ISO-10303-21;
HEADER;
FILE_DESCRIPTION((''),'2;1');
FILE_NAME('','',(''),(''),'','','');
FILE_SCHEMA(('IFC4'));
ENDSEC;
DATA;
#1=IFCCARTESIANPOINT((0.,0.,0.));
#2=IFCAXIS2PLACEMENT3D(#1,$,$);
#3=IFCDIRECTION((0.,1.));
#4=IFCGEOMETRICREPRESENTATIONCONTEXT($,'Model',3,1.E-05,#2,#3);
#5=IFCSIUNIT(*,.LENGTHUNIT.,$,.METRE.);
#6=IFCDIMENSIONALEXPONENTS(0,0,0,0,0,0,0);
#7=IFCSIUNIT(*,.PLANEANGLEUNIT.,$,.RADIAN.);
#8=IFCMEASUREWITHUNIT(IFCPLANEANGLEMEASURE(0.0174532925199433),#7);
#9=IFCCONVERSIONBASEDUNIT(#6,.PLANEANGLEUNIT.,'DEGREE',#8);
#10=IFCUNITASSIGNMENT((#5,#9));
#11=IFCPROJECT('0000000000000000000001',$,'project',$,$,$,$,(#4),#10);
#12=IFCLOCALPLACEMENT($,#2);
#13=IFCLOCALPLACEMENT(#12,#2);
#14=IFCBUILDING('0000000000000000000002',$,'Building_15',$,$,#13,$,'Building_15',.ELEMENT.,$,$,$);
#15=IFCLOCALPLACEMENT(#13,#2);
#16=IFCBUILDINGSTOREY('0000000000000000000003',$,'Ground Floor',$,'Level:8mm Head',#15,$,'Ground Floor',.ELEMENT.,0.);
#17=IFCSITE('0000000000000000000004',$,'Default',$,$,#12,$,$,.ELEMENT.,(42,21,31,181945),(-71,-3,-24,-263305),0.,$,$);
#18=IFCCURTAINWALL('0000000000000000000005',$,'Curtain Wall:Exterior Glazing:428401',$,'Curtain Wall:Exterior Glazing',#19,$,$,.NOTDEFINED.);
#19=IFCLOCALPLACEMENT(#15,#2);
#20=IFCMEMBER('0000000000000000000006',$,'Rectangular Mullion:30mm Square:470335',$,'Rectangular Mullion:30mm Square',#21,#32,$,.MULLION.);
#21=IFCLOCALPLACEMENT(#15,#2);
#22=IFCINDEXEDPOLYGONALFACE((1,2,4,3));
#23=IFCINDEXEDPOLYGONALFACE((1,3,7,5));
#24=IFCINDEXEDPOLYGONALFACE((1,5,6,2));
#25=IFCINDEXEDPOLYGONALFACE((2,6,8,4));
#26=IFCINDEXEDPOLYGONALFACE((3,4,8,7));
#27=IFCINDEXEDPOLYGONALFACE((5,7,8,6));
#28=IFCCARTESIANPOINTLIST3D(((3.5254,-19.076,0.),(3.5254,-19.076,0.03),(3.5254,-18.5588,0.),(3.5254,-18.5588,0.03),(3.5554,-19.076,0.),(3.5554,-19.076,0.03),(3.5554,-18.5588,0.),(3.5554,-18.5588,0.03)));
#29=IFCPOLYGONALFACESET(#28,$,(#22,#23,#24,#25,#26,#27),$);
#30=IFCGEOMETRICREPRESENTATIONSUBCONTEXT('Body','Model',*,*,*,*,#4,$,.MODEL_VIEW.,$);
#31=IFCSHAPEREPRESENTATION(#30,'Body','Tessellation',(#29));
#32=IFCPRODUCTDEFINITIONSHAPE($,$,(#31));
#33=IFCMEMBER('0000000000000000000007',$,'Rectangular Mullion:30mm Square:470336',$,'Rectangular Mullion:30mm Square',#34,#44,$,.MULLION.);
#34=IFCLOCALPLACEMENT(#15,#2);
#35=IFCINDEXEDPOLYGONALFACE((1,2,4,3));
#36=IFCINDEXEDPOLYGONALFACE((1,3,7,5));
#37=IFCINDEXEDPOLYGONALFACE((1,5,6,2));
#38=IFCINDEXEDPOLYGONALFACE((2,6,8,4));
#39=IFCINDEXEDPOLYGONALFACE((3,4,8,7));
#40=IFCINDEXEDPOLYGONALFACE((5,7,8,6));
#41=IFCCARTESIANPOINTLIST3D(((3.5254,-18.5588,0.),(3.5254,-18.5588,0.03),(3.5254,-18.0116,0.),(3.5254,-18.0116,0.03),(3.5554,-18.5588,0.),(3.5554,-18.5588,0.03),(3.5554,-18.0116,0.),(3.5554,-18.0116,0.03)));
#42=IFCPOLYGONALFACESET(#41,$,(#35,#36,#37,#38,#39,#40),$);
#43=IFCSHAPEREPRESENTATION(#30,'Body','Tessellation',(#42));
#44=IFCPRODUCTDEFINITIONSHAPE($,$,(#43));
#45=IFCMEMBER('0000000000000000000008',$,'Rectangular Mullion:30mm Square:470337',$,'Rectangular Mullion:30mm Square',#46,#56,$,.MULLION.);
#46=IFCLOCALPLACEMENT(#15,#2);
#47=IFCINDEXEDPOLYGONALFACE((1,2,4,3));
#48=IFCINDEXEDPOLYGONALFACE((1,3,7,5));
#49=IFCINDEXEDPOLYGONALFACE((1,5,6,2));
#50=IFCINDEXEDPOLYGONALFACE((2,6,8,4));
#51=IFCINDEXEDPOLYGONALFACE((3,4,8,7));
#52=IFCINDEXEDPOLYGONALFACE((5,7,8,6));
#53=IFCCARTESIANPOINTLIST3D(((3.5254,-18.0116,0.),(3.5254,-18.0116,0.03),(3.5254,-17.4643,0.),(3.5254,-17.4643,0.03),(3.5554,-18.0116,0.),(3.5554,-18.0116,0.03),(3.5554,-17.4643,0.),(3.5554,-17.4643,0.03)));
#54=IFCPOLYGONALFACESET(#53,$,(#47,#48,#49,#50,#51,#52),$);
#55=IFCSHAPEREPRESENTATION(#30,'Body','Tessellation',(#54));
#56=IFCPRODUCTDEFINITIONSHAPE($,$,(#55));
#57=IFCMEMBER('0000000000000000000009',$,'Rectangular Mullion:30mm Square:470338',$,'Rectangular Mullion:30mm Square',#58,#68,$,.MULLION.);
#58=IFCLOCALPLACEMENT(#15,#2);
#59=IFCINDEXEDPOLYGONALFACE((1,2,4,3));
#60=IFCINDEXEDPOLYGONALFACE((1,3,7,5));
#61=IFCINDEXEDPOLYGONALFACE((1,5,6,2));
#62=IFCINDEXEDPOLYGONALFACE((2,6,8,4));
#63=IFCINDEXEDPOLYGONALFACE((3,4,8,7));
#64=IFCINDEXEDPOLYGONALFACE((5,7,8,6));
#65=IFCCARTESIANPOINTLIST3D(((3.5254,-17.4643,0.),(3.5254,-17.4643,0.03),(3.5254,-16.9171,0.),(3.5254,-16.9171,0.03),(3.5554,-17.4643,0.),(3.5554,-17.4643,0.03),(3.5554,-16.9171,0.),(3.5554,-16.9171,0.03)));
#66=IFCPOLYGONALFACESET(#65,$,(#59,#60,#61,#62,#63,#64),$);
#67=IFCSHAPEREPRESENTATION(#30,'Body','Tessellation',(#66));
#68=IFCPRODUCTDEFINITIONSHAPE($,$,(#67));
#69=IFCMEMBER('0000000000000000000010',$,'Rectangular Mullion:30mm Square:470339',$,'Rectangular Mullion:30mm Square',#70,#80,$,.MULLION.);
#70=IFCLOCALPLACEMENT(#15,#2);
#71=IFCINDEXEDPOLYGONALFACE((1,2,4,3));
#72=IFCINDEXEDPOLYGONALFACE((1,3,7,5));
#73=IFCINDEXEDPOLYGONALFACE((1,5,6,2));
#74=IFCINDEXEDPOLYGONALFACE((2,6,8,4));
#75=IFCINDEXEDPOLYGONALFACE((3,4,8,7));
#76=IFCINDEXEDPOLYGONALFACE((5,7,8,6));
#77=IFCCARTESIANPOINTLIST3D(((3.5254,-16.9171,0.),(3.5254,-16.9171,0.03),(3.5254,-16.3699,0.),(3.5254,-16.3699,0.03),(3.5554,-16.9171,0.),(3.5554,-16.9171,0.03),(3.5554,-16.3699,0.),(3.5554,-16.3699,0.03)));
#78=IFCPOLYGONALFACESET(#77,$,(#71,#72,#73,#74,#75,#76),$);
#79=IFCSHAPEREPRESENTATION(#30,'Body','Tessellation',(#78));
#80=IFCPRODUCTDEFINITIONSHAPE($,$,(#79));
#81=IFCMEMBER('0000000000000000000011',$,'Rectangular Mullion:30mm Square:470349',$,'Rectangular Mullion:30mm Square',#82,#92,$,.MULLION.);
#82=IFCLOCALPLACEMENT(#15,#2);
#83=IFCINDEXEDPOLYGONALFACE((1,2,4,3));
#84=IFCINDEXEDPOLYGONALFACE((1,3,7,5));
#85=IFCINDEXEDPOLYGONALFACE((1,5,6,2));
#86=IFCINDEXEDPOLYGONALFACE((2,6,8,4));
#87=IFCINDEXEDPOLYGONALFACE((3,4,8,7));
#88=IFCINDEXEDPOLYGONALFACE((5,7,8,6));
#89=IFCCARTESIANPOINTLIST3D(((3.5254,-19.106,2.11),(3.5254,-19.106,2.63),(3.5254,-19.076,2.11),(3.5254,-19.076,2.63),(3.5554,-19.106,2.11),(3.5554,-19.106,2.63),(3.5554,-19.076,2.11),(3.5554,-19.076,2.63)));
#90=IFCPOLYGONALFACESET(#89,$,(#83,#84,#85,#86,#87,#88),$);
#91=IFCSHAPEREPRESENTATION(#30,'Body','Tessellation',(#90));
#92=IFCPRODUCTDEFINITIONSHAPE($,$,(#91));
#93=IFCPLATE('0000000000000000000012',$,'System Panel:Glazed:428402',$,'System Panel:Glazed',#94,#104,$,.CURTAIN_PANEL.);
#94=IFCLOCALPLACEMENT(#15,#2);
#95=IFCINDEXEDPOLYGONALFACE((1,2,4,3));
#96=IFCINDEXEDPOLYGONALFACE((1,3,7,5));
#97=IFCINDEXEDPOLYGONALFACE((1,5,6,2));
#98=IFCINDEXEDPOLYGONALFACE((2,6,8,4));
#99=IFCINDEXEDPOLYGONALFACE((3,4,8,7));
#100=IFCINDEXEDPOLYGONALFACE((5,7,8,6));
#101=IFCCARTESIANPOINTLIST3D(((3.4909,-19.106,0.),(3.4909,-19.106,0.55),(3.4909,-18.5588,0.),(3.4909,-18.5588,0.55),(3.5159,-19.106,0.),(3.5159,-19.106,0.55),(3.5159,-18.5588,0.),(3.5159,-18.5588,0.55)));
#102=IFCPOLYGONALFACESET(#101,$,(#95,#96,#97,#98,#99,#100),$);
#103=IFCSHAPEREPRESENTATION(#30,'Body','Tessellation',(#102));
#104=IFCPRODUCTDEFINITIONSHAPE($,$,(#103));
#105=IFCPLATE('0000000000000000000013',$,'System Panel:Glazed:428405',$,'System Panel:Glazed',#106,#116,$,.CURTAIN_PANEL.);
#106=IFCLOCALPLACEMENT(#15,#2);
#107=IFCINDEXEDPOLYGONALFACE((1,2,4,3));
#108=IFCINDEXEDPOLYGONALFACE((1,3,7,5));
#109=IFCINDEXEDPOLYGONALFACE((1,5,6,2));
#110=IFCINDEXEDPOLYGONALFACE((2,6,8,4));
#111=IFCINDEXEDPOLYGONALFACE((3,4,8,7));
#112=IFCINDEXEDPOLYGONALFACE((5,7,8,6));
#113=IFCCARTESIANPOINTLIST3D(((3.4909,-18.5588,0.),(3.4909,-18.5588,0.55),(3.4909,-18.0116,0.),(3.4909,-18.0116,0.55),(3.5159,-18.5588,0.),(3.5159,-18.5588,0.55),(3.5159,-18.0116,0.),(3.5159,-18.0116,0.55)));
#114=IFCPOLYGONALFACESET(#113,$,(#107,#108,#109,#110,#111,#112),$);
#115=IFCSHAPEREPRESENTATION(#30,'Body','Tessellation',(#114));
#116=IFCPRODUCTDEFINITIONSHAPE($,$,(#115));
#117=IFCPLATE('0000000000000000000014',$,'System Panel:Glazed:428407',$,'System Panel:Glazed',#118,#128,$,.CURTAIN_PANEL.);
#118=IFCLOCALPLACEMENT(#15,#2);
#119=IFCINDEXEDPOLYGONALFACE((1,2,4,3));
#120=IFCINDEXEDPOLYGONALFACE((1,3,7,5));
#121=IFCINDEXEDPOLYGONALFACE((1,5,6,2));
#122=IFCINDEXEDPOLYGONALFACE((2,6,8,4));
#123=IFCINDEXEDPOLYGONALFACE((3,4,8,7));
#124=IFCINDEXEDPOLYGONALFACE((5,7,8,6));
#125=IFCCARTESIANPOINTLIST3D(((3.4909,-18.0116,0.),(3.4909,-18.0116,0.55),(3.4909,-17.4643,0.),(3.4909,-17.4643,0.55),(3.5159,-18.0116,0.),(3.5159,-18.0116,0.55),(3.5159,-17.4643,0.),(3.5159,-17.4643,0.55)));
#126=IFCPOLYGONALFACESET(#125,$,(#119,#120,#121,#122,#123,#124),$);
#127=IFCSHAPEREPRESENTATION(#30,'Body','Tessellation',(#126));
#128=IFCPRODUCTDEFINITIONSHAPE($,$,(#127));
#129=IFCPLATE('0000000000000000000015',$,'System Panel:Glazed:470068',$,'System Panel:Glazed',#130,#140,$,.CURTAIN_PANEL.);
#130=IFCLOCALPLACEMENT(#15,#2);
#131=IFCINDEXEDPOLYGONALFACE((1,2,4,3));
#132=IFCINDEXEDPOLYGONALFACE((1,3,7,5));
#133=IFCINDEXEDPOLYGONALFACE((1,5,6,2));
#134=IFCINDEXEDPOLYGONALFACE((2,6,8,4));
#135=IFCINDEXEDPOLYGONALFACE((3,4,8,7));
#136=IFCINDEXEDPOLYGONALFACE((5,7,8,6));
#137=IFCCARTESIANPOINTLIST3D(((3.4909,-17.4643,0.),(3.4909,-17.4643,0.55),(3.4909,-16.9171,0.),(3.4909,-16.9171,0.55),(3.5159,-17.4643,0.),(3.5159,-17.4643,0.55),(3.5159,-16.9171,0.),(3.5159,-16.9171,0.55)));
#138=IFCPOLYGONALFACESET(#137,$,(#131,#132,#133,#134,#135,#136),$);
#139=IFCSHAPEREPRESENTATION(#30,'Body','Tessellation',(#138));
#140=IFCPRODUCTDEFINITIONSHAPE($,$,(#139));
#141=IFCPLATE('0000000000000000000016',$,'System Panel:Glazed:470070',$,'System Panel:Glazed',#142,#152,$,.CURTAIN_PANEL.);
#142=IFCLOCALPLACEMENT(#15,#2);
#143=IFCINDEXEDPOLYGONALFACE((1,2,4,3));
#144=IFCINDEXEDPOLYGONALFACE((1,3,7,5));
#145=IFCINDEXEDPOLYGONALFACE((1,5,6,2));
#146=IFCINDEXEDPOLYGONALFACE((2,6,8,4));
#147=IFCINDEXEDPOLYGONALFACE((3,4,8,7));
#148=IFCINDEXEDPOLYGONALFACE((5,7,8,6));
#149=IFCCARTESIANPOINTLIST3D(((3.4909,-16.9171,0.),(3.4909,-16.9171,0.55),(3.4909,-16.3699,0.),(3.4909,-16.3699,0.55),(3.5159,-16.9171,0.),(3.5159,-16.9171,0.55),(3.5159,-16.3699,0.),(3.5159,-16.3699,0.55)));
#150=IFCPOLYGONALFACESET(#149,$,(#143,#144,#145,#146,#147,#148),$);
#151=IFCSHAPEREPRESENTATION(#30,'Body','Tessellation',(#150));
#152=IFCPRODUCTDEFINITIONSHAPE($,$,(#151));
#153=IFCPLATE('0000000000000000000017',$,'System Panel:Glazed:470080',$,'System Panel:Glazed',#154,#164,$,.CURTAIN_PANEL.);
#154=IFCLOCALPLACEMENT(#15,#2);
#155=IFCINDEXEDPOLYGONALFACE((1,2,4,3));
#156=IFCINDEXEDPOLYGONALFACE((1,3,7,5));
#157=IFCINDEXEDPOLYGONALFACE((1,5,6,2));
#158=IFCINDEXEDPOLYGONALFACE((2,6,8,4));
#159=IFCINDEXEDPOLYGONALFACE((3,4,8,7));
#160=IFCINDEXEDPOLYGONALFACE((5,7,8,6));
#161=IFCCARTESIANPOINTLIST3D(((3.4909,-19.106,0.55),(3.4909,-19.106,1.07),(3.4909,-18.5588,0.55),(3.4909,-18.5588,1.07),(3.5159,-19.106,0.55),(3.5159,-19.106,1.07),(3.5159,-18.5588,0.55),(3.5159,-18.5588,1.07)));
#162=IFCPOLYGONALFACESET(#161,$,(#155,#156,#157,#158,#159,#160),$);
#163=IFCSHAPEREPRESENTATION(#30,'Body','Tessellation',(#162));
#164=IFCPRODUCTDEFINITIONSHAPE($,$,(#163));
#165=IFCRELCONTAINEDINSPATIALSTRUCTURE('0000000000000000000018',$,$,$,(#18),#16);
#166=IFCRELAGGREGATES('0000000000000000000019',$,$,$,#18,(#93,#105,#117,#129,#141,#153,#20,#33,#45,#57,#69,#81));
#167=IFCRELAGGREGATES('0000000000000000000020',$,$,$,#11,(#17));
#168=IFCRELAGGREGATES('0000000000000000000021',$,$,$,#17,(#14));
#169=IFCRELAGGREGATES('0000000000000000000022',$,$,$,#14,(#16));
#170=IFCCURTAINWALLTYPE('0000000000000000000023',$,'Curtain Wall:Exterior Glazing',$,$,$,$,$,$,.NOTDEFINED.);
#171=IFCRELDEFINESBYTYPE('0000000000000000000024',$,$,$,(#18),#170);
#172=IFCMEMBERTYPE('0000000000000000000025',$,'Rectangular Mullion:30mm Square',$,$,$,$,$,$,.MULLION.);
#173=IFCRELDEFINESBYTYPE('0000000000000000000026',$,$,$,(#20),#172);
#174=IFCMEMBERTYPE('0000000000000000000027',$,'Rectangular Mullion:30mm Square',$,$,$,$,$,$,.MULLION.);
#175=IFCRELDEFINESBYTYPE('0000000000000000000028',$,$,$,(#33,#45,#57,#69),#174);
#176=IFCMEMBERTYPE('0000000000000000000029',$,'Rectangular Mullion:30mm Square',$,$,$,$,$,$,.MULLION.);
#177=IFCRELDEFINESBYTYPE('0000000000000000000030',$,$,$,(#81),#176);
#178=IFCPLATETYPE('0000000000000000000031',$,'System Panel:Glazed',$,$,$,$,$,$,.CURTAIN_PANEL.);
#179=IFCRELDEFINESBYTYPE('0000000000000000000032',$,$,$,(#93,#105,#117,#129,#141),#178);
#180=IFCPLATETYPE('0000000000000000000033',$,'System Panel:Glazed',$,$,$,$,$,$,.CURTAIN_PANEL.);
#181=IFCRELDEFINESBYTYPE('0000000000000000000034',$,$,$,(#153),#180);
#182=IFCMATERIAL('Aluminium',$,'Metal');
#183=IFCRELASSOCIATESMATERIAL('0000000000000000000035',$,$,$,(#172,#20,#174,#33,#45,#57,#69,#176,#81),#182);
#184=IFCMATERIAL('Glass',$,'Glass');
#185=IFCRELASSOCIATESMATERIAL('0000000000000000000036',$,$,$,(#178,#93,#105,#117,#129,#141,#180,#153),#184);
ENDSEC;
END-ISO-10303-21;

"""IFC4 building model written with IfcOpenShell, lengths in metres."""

from ifc_helpers import new_model, entity, si_unit, converted_unit, direction, frame, origin, place, context, subcontext, project, spatial, indexed_curve, outline, extrude, source, transform, mapped, material, type_object, type_shapes, element, aggregate, save


model = new_model("IFC4")

# Units and contexts
model_context = context("Model", 3, precision=1e-05, world=origin(), true_north=direction((0.0, 1.0)))
body_context = subcontext(model_context, "Body", "Model", "MODEL_VIEW")
ifc_project = project(units=[si_unit("LENGTHUNIT", "METRE"), converted_unit("PLANEANGLEUNIT", "DEGREE", entity("IfcPlaneAngleMeasure", 0.0174532925199433), si_unit("PLANEANGLEUNIT", "RADIAN"), dimensions=[0, 0, 0, 0, 0, 0, 0])], contexts=[model_context])

# Site, building, storey
site_placement = place(None, origin())
site = spatial("IfcSite", under=ifc_project, at=site_placement, Name="Default", CompositionType="ELEMENT", RefLatitude=(42, 21, 31, 181945), RefLongitude=(-71, -3, -24, -263305), RefElevation=0.0)
building_placement = place(site_placement, origin())
building = spatial("IfcBuilding", under=site, at=building_placement, Name="Building_15", LongName="Building_15", CompositionType="ELEMENT")
storey_placement = place(building_placement, origin())
storey = spatial("IfcBuildingStorey", under=building, at=storey_placement, Name="Ground Floor", ObjectType="Level:8mm Head", LongName="Ground Floor", CompositionType="ELEMENT", Elevation=0.0)

# Curtain wall, members, plates
curtain_wall_type = type_object("IfcCurtainWallType", Name="Curtain Wall:Exterior Glazing", PredefinedType="NOTDEFINED")
curtain_wall_placement = place(storey_placement, origin())
curtain_wall = element("IfcCurtainWall", 1, at=curtain_wall_placement, inside=storey, type_object=curtain_wall_type, Name="Curtain Wall:Exterior Glazing:428401", ObjectType="Curtain Wall:Exterior Glazing", PredefinedType="NOTDEFINED")
ifc_material_1 = material(Name="Aluminium", Category="Metal")
member_type_1 = type_object("IfcMemberType", Name="Rectangular Mullion:30mm Square", PredefinedType="MULLION", material=ifc_material_1)
shared_shape_1 = source(origin(), body_context, "Body", "SweptSolid", [
    extrude(outline(indexed_curve([(-0.015, -0.015), (0.015, -0.015), (0.015, 0.015), (-0.015, 0.015), (-0.015, -0.015)], self_intersect=False)), frame((-0.015, 0.0, -0.5172), z_axis=(0.0, 0.0, 1.0), x_axis=(-1.0, 0.0, 0.0)), (0.0, 0.0, 1.0), 0.5172),
])
type_shapes(member_type_1, [shared_shape_1])
member_1_placement = place(curtain_wall_placement, frame((3.5404, -19.076, 0.0), z_axis=(0.0, -1.0, 0.0), x_axis=(0.0, 0.0, -1.0)))
member_1 = element("IfcMember", 2, at=member_1_placement, type_object=member_type_1, material=ifc_material_1, Name="Rectangular Mullion:30mm Square:470335", ObjectType="Rectangular Mullion:30mm Square", PredefinedType="MULLION", context=body_context, shape_type="MappedRepresentation", body=[
    mapped(shared_shape_1, transform((0.0, 0.0, 0.0), scale=1.0)),
])
member_type_2 = type_object("IfcMemberType", Name="Rectangular Mullion:30mm Square", PredefinedType="MULLION", material=ifc_material_1)
shared_shape_2 = source(origin(), body_context, "Body", "SweptSolid", [
    extrude(outline(indexed_curve([(-0.015, -0.015), (0.015, -0.015), (0.015, 0.015), (-0.015, 0.015), (-0.015, -0.015)], self_intersect=False)), frame((-0.015, 0.0, -0.5472), z_axis=(0.0, 0.0, 1.0), x_axis=(-1.0, 0.0, 0.0)), (0.0, 0.0, 1.0), 0.5472),
])
type_shapes(member_type_2, [shared_shape_2])
member_2_placement = place(curtain_wall_placement, frame((3.5404, -18.5588, 0.0), z_axis=(0.0, -1.0, 0.0), x_axis=(0.0, 0.0, -1.0)))
member_2 = element("IfcMember", 3, at=member_2_placement, type_object=member_type_2, material=ifc_material_1, Name="Rectangular Mullion:30mm Square:470336", ObjectType="Rectangular Mullion:30mm Square", PredefinedType="MULLION", context=body_context, shape_type="MappedRepresentation", body=[
    mapped(shared_shape_2, transform((0.0, 0.0, 0.0), scale=1.0)),
])
member_3_placement = place(curtain_wall_placement, frame((3.5404, -18.0116, 0.0), z_axis=(0.0, -1.0, 0.0), x_axis=(0.0, 0.0, -1.0)))
member_3 = element("IfcMember", 4, at=member_3_placement, type_object=member_type_2, material=ifc_material_1, Name="Rectangular Mullion:30mm Square:470337", ObjectType="Rectangular Mullion:30mm Square", PredefinedType="MULLION", context=body_context, shape_type="MappedRepresentation", body=[
    mapped(shared_shape_2, transform((0.0, 0.0, 0.0), scale=1.0)),
])
member_4_placement = place(curtain_wall_placement, frame((3.5404, -17.4643, 0.0), z_axis=(0.0, -1.0, 0.0), x_axis=(0.0, 0.0, -1.0)))
member_4 = element("IfcMember", 5, at=member_4_placement, type_object=member_type_2, material=ifc_material_1, Name="Rectangular Mullion:30mm Square:470338", ObjectType="Rectangular Mullion:30mm Square", PredefinedType="MULLION", context=body_context, shape_type="MappedRepresentation", body=[
    mapped(shared_shape_2, transform((0.0, 0.0, 0.0), scale=1.0)),
])
member_5_placement = place(curtain_wall_placement, frame((3.5404, -16.9171, 0.0), z_axis=(0.0, -1.0, 0.0), x_axis=(0.0, 0.0, -1.0)))
member_5 = element("IfcMember", 6, at=member_5_placement, type_object=member_type_2, material=ifc_material_1, Name="Rectangular Mullion:30mm Square:470339", ObjectType="Rectangular Mullion:30mm Square", PredefinedType="MULLION", context=body_context, shape_type="MappedRepresentation", body=[
    mapped(shared_shape_2, transform((0.0, 0.0, 0.0), scale=1.0)),
])
member_type_3 = type_object("IfcMemberType", Name="Rectangular Mullion:30mm Square", PredefinedType="MULLION", material=ifc_material_1)
shared_shape_3 = source(origin(), body_context, "Body", "SweptSolid", [
    extrude(outline(indexed_curve([(-0.015, -0.015), (0.015, -0.015), (0.015, 0.015), (-0.015, 0.015), (-0.015, -0.015)], self_intersect=False)), frame((-0.015, 0.0, -0.52), z_axis=(0.0, 0.0, 1.0), x_axis=(-1.0, 0.0, 0.0)), (0.0, 0.0, 1.0), 0.52),
])
type_shapes(member_type_3, [shared_shape_3])
member_6_placement = place(curtain_wall_placement, frame((3.5404, -19.106, 2.63), z_axis=(0.0, 0.0, 1.0), x_axis=(0.0, -1.0, 0.0)))
member_6 = element("IfcMember", 7, at=member_6_placement, type_object=member_type_3, material=ifc_material_1, Name="Rectangular Mullion:30mm Square:470349", ObjectType="Rectangular Mullion:30mm Square", PredefinedType="MULLION", context=body_context, shape_type="MappedRepresentation", body=[
    mapped(shared_shape_3, transform((0.0, 0.0, 0.0), scale=1.0)),
])
ifc_material_2 = material(Name="Glass", Category="Glass")
plate_type_1 = type_object("IfcPlateType", Name="System Panel:Glazed", PredefinedType="CURTAIN_PANEL", material=ifc_material_2)
shared_shape_4 = source(origin(), body_context, "Body", "SweptSolid", [
    extrude(outline(indexed_curve([(-0.0125, -0.2736), (0.0125, -0.2736), (0.0125, 0.2736), (-0.0125, 0.2736), (-0.0125, -0.2736)], self_intersect=False)), frame((0.0, 0.037, 0.0), z_axis=(0.0, 0.0, 1.0), x_axis=(0.0, 1.0, 0.0)), (0.0, 0.0, 1.0), 0.55),
])
type_shapes(plate_type_1, [shared_shape_4])
plate_1_placement = place(curtain_wall_placement, frame((3.5404, -18.8324, 0.0), z_axis=(0.0, 0.0, 1.0), x_axis=(0.0, 1.0, 0.0)))
plate_1 = element("IfcPlate", 8, at=plate_1_placement, type_object=plate_type_1, material=ifc_material_2, Name="System Panel:Glazed:428402", ObjectType="System Panel:Glazed", PredefinedType="CURTAIN_PANEL", context=body_context, shape_type="MappedRepresentation", body=[
    mapped(shared_shape_4, transform((0.0, 0.0, 0.0), scale=1.0)),
])
plate_2_placement = place(curtain_wall_placement, frame((3.5404, -18.2852, 0.0), z_axis=(0.0, 0.0, 1.0), x_axis=(0.0, 1.0, 0.0)))
plate_2 = element("IfcPlate", 9, at=plate_2_placement, type_object=plate_type_1, material=ifc_material_2, Name="System Panel:Glazed:428405", ObjectType="System Panel:Glazed", PredefinedType="CURTAIN_PANEL", context=body_context, shape_type="MappedRepresentation", body=[
    mapped(shared_shape_4, transform((0.0, 0.0, 0.0), scale=1.0)),
])
plate_3_placement = place(curtain_wall_placement, frame((3.5404, -17.738, 0.0), z_axis=(0.0, 0.0, 1.0), x_axis=(0.0, 1.0, 0.0)))
plate_3 = element("IfcPlate", 10, at=plate_3_placement, type_object=plate_type_1, material=ifc_material_2, Name="System Panel:Glazed:428407", ObjectType="System Panel:Glazed", PredefinedType="CURTAIN_PANEL", context=body_context, shape_type="MappedRepresentation", body=[
    mapped(shared_shape_4, transform((0.0, 0.0, 0.0), scale=1.0)),
])
plate_4_placement = place(curtain_wall_placement, frame((3.5404, -17.1907, 0.0), z_axis=(0.0, 0.0, 1.0), x_axis=(0.0, 1.0, 0.0)))
plate_4 = element("IfcPlate", 11, at=plate_4_placement, type_object=plate_type_1, material=ifc_material_2, Name="System Panel:Glazed:470068", ObjectType="System Panel:Glazed", PredefinedType="CURTAIN_PANEL", context=body_context, shape_type="MappedRepresentation", body=[
    mapped(shared_shape_4, transform((0.0, 0.0, 0.0), scale=1.0)),
])
plate_5_placement = place(curtain_wall_placement, frame((3.5404, -16.6435, 0.0), z_axis=(0.0, 0.0, 1.0), x_axis=(0.0, 1.0, 0.0)))
plate_5 = element("IfcPlate", 12, at=plate_5_placement, type_object=plate_type_1, material=ifc_material_2, Name="System Panel:Glazed:470070", ObjectType="System Panel:Glazed", PredefinedType="CURTAIN_PANEL", context=body_context, shape_type="MappedRepresentation", body=[
    mapped(shared_shape_4, transform((0.0, 0.0, 0.0), scale=1.0)),
])
plate_type_2 = type_object("IfcPlateType", Name="System Panel:Glazed", PredefinedType="CURTAIN_PANEL", material=ifc_material_2)
shared_shape_5 = source(origin(), body_context, "Body", "SweptSolid", [
    extrude(outline(indexed_curve([(-0.0125, -0.2736), (0.0125, -0.2736), (0.0125, 0.2736), (-0.0125, 0.2736), (-0.0125, -0.2736)], self_intersect=False)), frame((0.0, 0.037, 0.0), z_axis=(0.0, 0.0, 1.0), x_axis=(0.0, 1.0, 0.0)), (0.0, 0.0, 1.0), 0.52),
])
type_shapes(plate_type_2, [shared_shape_5])
plate_6_placement = place(curtain_wall_placement, frame((3.5404, -18.8324, 0.55), z_axis=(0.0, 0.0, 1.0), x_axis=(0.0, 1.0, 0.0)))
plate_6 = element("IfcPlate", 13, at=plate_6_placement, type_object=plate_type_2, material=ifc_material_2, Name="System Panel:Glazed:470080", ObjectType="System Panel:Glazed", PredefinedType="CURTAIN_PANEL", context=body_context, shape_type="MappedRepresentation", body=[
    mapped(shared_shape_5, transform((0.0, 0.0, 0.0), scale=1.0)),
])
aggregate(curtain_wall, [plate_1, plate_2, plate_3, plate_4, plate_5, plate_6, member_1, member_2, member_3, member_4, member_5, member_6])

save(model, "model.ifc")
